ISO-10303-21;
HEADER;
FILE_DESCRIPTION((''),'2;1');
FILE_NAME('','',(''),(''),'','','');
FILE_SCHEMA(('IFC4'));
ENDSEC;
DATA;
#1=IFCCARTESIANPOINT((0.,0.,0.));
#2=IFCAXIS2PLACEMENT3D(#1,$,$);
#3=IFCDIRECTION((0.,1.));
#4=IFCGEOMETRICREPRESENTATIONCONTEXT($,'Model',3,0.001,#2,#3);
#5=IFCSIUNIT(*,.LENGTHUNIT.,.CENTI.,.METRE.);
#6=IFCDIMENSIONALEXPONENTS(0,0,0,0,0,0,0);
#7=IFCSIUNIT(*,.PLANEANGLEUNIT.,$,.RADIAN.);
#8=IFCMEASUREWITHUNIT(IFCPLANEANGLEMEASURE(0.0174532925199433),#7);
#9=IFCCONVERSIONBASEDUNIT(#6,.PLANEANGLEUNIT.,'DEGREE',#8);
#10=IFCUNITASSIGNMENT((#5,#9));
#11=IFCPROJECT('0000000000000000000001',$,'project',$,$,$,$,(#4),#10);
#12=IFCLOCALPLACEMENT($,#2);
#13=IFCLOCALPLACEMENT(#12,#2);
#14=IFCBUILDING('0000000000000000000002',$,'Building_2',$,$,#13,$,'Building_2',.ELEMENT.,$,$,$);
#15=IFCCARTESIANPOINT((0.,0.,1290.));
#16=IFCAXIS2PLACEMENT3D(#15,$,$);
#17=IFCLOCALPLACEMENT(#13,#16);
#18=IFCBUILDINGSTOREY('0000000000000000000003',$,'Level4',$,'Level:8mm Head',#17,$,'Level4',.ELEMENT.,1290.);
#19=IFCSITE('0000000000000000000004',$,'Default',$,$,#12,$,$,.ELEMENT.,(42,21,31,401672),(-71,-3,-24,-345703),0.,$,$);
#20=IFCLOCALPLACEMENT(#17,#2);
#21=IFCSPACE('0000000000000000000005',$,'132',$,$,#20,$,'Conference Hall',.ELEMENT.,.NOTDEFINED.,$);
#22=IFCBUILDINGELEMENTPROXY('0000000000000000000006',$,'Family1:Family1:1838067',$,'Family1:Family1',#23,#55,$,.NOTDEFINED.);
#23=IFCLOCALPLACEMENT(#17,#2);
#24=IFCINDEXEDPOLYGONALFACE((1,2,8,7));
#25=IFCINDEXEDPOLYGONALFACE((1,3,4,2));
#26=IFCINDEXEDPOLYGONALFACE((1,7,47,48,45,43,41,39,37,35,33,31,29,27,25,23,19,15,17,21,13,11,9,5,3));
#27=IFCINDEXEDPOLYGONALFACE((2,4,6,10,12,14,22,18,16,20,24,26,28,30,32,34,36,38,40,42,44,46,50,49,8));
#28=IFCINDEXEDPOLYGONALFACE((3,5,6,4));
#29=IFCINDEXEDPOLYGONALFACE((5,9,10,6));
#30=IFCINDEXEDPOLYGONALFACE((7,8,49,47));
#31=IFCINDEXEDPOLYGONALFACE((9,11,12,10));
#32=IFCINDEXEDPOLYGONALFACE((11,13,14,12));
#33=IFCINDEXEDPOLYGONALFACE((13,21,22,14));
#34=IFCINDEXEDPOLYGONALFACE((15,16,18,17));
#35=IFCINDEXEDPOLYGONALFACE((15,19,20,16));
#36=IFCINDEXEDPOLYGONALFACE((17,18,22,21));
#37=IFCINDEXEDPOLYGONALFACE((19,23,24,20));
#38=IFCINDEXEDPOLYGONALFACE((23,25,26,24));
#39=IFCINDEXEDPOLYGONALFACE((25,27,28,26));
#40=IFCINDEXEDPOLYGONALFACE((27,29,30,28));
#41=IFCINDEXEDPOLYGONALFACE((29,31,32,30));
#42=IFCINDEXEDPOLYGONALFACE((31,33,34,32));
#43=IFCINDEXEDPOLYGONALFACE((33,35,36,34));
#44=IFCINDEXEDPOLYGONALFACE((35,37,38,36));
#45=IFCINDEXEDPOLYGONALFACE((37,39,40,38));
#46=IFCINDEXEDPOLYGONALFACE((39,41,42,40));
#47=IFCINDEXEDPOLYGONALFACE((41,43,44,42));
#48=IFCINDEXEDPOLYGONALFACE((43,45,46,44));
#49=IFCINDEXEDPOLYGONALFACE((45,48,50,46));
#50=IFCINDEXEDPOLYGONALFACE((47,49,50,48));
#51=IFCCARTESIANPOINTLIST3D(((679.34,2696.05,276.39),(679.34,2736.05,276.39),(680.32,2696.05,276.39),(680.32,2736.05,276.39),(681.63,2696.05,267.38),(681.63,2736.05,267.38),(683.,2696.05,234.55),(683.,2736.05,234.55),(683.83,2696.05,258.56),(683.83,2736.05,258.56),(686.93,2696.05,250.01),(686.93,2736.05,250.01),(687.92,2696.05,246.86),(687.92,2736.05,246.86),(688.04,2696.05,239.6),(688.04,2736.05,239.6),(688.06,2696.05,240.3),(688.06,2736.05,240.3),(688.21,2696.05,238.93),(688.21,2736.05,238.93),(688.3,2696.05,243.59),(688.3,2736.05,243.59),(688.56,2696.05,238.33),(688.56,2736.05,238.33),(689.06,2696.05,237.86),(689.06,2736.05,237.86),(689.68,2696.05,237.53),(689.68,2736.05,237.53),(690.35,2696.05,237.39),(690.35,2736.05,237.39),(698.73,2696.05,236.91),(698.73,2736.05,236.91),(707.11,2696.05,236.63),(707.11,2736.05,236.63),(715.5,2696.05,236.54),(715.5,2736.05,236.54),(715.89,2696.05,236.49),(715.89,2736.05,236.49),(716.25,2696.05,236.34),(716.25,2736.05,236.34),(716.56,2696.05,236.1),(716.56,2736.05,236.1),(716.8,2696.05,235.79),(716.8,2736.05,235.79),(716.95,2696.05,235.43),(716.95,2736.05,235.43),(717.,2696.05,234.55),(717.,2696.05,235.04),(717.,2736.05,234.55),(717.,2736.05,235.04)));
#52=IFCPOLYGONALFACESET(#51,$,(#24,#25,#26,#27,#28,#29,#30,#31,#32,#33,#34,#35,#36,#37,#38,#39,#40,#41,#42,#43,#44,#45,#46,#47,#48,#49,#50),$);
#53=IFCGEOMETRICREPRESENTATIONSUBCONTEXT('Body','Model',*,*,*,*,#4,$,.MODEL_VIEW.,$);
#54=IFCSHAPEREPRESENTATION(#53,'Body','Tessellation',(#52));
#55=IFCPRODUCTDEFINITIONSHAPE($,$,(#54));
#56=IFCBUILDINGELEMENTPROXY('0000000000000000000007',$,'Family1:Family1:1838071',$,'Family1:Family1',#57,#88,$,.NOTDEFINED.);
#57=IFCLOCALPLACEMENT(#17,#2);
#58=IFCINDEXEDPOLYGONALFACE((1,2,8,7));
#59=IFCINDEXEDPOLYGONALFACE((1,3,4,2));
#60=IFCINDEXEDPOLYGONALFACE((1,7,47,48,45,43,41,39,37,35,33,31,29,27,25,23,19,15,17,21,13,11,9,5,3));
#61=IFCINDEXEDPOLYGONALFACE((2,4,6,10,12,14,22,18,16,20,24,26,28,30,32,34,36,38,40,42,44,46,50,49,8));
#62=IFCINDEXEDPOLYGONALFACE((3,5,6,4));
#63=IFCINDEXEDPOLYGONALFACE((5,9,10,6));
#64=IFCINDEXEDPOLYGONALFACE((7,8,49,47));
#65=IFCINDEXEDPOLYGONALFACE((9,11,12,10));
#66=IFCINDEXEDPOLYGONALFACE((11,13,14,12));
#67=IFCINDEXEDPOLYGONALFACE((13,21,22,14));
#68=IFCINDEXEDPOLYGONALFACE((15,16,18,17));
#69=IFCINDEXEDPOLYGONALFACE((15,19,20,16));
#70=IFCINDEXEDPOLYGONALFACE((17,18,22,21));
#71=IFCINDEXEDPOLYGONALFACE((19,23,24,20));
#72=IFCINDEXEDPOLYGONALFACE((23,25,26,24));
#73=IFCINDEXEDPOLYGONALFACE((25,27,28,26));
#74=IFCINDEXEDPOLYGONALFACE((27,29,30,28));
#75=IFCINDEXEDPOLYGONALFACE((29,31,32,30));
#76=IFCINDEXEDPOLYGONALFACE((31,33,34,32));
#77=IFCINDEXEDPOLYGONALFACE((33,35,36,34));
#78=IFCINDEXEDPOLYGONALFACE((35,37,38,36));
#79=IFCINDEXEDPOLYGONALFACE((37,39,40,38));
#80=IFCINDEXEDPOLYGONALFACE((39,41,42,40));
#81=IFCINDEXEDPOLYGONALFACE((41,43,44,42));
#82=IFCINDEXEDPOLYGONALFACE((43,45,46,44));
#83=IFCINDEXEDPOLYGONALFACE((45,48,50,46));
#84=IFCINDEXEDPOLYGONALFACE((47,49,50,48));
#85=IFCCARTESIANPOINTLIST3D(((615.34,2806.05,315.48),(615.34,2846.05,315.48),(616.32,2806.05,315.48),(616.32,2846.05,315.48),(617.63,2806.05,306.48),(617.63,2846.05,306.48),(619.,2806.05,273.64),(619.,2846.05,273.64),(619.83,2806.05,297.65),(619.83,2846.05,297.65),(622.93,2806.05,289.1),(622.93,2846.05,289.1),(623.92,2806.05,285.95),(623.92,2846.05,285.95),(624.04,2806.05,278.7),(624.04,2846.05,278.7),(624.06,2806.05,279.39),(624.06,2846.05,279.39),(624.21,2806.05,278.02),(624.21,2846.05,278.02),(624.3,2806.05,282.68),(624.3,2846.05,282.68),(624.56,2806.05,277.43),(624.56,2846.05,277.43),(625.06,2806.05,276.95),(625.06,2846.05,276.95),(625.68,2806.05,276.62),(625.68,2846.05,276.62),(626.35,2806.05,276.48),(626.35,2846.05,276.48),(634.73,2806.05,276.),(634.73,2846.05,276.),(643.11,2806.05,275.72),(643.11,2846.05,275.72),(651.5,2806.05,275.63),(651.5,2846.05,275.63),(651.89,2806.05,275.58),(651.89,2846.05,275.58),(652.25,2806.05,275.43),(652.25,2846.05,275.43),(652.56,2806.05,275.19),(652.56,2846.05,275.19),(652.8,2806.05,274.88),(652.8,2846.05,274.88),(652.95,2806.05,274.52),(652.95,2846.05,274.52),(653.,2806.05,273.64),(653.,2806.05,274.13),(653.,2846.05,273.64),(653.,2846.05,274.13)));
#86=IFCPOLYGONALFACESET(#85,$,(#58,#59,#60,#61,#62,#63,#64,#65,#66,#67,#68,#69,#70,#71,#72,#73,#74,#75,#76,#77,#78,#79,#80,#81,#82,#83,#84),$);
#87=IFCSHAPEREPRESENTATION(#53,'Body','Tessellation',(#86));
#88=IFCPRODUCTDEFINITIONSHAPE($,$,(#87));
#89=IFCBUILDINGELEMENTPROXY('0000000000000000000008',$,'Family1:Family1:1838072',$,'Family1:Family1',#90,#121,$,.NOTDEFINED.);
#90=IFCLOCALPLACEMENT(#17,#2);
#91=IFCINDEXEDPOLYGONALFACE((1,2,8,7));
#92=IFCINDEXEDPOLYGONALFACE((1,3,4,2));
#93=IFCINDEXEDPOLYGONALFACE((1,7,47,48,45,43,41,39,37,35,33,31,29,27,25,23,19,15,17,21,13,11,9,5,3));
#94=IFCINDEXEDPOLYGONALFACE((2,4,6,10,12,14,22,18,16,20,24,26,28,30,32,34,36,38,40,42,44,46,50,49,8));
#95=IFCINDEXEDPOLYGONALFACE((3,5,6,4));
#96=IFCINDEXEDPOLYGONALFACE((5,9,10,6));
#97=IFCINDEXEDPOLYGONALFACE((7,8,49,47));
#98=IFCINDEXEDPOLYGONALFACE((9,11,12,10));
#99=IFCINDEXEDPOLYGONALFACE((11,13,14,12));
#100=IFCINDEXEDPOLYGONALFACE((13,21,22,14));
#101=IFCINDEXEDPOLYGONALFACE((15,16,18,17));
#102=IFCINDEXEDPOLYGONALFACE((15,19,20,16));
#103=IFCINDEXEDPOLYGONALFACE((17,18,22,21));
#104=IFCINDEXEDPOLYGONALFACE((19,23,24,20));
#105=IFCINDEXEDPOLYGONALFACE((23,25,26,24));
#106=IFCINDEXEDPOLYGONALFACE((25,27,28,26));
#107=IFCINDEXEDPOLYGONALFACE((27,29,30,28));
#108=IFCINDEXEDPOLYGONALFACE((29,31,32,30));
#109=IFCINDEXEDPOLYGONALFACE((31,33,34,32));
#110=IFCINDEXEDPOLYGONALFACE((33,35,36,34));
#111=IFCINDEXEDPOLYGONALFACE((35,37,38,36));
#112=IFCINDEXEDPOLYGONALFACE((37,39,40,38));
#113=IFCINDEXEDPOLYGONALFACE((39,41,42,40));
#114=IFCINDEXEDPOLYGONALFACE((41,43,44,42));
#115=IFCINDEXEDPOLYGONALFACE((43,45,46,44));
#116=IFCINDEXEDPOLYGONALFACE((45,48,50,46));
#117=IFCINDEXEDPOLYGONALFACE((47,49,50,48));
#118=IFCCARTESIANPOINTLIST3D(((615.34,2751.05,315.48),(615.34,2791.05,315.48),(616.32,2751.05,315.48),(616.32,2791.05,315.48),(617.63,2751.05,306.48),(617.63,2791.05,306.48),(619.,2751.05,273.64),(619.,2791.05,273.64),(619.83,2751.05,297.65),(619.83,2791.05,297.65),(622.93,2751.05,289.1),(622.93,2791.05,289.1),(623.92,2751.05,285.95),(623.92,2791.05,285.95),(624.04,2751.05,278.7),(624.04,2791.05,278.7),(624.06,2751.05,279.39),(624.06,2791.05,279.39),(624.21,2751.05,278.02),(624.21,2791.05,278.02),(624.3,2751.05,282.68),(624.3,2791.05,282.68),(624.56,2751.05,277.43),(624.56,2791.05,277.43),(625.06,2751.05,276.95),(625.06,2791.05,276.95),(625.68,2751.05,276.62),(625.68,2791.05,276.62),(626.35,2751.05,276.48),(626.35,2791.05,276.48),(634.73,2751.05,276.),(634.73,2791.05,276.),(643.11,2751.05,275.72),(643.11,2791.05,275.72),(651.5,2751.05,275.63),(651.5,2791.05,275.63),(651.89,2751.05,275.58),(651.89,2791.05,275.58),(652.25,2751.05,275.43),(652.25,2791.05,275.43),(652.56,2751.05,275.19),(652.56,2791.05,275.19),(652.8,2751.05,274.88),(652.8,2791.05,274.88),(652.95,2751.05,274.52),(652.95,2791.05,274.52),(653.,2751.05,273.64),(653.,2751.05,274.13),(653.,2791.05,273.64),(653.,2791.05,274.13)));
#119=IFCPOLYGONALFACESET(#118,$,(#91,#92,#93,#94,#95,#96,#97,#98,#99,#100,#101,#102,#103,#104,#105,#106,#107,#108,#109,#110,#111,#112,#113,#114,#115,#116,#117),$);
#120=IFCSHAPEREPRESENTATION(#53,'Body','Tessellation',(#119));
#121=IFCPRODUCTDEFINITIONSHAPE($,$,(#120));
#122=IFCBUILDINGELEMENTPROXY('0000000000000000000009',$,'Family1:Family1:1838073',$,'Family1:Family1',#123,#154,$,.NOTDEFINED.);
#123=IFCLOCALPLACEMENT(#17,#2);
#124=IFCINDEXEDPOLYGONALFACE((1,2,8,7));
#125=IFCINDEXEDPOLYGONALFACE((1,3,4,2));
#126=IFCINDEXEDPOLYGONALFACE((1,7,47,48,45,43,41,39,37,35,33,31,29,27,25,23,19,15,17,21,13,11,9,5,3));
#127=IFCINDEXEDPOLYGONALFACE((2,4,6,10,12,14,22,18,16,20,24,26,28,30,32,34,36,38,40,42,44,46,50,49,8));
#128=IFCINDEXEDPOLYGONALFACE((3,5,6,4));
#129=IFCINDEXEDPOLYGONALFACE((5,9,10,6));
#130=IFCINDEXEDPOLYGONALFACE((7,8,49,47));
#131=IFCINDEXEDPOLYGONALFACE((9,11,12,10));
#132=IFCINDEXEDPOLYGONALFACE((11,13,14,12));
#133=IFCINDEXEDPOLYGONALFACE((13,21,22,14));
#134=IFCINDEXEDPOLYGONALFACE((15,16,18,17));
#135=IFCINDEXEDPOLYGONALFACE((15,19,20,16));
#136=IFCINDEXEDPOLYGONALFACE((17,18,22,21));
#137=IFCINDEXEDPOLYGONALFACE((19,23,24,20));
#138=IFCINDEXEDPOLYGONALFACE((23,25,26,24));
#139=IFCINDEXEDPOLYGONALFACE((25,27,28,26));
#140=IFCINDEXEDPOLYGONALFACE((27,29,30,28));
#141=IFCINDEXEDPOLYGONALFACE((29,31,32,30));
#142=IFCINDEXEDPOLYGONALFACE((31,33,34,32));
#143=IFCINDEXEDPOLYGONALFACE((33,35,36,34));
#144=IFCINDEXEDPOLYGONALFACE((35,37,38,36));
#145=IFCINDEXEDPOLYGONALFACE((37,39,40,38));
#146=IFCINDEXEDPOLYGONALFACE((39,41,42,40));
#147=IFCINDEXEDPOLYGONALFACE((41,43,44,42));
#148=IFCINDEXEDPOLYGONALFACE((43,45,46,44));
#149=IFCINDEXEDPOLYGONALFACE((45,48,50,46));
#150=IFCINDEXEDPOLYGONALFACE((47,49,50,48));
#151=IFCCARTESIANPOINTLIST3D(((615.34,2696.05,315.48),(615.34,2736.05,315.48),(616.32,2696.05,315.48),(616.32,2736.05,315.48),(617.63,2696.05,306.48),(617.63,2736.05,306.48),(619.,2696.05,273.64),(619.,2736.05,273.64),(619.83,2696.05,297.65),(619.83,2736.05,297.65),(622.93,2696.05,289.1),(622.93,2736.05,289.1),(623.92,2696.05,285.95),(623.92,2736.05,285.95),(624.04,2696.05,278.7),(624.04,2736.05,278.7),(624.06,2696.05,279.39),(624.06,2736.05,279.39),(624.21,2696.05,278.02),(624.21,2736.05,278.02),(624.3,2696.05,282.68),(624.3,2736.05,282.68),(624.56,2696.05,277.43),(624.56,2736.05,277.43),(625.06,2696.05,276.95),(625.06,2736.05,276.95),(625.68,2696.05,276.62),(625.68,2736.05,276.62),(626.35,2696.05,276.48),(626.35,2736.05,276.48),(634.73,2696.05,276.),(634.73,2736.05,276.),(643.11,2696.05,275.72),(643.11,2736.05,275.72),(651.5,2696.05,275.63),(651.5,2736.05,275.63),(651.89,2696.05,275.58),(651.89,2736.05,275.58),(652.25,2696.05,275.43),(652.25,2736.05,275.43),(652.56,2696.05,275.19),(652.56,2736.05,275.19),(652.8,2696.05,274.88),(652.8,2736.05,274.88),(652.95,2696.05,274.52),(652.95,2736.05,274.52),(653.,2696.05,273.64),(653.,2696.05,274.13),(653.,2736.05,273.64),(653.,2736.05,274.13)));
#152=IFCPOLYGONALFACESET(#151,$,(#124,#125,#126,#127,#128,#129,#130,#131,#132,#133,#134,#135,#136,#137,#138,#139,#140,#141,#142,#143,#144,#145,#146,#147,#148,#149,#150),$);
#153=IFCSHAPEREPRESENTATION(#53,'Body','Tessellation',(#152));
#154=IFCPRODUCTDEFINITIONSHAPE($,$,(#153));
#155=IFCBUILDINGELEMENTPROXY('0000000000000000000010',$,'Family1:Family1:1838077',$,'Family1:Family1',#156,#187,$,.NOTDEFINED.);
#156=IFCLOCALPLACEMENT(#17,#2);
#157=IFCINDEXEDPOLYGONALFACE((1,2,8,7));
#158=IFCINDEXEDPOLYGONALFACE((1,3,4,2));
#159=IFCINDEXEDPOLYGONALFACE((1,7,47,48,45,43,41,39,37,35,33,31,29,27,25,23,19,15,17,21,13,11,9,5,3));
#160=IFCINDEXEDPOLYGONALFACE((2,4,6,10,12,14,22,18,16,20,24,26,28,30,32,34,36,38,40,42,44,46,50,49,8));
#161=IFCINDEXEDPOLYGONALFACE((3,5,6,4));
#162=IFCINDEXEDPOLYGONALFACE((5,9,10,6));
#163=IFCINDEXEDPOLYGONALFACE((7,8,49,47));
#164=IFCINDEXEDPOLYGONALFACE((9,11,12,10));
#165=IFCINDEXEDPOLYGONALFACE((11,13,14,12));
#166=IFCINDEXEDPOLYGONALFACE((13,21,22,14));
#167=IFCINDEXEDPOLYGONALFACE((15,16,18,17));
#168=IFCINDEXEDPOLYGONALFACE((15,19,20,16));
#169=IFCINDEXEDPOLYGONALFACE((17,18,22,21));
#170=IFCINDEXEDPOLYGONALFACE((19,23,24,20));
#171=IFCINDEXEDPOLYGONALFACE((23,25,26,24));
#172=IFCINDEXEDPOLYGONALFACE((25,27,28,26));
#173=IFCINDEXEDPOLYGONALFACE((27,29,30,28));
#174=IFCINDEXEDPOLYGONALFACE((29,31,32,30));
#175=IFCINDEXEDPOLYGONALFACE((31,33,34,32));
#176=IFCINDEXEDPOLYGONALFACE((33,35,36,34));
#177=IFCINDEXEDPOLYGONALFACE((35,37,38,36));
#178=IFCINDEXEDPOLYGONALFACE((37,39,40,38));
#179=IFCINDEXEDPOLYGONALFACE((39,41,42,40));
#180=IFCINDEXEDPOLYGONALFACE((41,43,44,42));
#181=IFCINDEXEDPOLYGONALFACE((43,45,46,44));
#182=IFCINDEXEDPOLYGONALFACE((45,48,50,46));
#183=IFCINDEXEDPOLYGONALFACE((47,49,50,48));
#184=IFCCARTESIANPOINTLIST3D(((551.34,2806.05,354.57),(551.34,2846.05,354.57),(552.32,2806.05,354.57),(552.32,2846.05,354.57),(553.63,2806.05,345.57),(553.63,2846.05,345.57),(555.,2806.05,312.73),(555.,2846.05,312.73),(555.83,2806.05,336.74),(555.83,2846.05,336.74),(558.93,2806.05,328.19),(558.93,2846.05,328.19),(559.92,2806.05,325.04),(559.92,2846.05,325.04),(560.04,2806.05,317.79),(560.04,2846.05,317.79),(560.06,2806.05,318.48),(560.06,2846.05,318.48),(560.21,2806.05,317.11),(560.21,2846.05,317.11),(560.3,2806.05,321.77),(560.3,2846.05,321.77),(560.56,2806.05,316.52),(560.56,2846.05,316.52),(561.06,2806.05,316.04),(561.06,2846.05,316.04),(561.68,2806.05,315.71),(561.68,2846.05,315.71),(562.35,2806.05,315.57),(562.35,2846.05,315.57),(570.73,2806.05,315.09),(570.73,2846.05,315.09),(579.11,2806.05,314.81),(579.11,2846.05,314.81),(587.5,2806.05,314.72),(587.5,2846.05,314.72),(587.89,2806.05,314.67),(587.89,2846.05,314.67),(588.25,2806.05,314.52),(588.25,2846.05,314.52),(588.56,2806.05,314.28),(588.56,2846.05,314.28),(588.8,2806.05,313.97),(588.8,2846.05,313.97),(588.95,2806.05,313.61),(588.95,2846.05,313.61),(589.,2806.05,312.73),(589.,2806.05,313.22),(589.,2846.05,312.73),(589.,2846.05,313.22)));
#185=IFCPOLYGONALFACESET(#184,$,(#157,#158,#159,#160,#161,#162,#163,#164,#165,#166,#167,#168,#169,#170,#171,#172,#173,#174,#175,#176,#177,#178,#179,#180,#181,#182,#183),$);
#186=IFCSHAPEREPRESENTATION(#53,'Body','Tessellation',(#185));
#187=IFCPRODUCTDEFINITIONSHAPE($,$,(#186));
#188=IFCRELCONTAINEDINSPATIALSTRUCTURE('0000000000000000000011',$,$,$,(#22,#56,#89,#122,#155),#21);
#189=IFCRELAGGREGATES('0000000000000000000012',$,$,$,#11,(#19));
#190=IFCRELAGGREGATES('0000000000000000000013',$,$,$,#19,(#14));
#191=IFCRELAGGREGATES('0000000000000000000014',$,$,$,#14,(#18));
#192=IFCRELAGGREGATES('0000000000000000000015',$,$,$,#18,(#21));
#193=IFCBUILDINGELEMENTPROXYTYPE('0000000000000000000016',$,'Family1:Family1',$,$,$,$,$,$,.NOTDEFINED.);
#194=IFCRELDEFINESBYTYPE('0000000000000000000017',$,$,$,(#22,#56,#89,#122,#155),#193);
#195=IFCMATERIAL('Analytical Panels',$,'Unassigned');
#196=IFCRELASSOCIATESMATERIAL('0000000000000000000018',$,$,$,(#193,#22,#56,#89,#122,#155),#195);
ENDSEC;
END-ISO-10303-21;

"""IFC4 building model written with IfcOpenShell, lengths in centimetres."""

from ifc_helpers import new_model, entity, si_unit, converted_unit, direction, frame, origin, place, context, subcontext, project, spatial, line, arc, indexed_curve, outline, extrude, source, transform, mapped, material, type_object, type_shapes, element, save


model = new_model("IFC4")

# Units and contexts
model_context = context("Model", 3, precision=0.001, world=origin(), true_north=direction((0.0, 1.0)))
body_context = subcontext(model_context, "Body", "Model", "MODEL_VIEW")
ifc_project = project(units=[si_unit("LENGTHUNIT", "METRE", prefix="CENTI"), converted_unit("PLANEANGLEUNIT", "DEGREE", entity("IfcPlaneAngleMeasure", 0.0174532925199433), si_unit("PLANEANGLEUNIT", "RADIAN"), dimensions=[0, 0, 0, 0, 0, 0, 0])], contexts=[model_context])

# Site, building, storey, space
site_placement = place(None, origin())
site = spatial("IfcSite", under=ifc_project, at=site_placement, Name="Default", CompositionType="ELEMENT", RefLatitude=(42, 21, 31, 401672), RefLongitude=(-71, -3, -24, -345703), RefElevation=0.0)
building_placement = place(site_placement, origin())
building = spatial("IfcBuilding", under=site, at=building_placement, Name="Building_2", LongName="Building_2", CompositionType="ELEMENT")
storey_placement = place(building_placement, frame((0.0, 0.0, 1290.0)))
storey = spatial("IfcBuildingStorey", under=building, at=storey_placement, Name="Level4", ObjectType="Level:8mm Head", LongName="Level4", CompositionType="ELEMENT", Elevation=1290.0)
space_placement = place(storey_placement, origin())
space = spatial("IfcSpace", under=storey, at=space_placement, Name="132", LongName="Conference Hall", CompositionType="ELEMENT", PredefinedType="NOTDEFINED")

# Building element proxies
ifc_material_1 = material(Name="Analytical Panels", Category="Unassigned")
building_element_proxy_type_1 = type_object("IfcBuildingElementProxyType", Name="Family1:Family1", PredefinedType="NOTDEFINED", material=ifc_material_1)
shared_shape_1 = source(origin(), body_context, "Body", "SweptSolid", [
    extrude(outline(indexed_curve([(-11.13, -13.3), (30.87, -13.3), (30.78, -12.32), (17.19, -11.21), (3.93, -8.04), (-0.94, -7.2), (-5.84, -7.76), (-7.84, -7.43), (-8.94, -5.73), (-10.68, 6.74), (-11.98, 19.25), (-12.51, 20.27), (-13.6, 20.61), (-14.09, 20.57)], segments=[line(1, 2, 3), arc(3, 4, 5), arc(5, 6, 7), arc(7, 8, 9), arc(9, 10, 11), arc(11, 12, 13), line(13, 14, 1)], self_intersect=False)), frame((-20.0, 6.72, 12.25), z_axis=(1.0, 0.0, 0.0), x_axis=(0.0, 0.087156, 0.996195)), (0.0, 0.0, 1.0), 40.0),
])
type_shapes(building_element_proxy_type_1, [shared_shape_1])
for number, where, z_axis, x_axis, name in (
    (1, (702.0, 2716.05, 234.55), (0.0, 0.0, 1.0), (0.0, 1.0, 0.0), "Family1:Family1:1838067"),
    (2, (638.0, 2826.05, 273.64), (0.0, 0.0, 1.0), (0.0, 1.0, 0.0), "Family1:Family1:1838071"),
    (3, (638.0, 2771.05, 273.64), (0.0, 0.0, 1.0), (0.0, 1.0, 0.0), "Family1:Family1:1838072"),
    (4, (638.0, 2716.05, 273.64), (0.0, 0.0, 1.0), (0.0, 1.0, 0.0), "Family1:Family1:1838073"),
    (5, (574.0, 2826.05, 312.73), (0.0, 0.0, 1.0), (0.0, 1.0, 0.0), "Family1:Family1:1838077"),
):
    element("IfcBuildingElementProxy", number, at=place(space_placement, frame(where, z_axis=z_axis, x_axis=x_axis)), inside=space, type_object=building_element_proxy_type_1, material=ifc_material_1, Name=name, ObjectType="Family1:Family1", PredefinedType="NOTDEFINED", context=body_context, shape_type="MappedRepresentation", body=[
        mapped(shared_shape_1, transform((0.0, 0.0, 0.0), scale=1.0)),
    ])

save(model, "model.ifc")
